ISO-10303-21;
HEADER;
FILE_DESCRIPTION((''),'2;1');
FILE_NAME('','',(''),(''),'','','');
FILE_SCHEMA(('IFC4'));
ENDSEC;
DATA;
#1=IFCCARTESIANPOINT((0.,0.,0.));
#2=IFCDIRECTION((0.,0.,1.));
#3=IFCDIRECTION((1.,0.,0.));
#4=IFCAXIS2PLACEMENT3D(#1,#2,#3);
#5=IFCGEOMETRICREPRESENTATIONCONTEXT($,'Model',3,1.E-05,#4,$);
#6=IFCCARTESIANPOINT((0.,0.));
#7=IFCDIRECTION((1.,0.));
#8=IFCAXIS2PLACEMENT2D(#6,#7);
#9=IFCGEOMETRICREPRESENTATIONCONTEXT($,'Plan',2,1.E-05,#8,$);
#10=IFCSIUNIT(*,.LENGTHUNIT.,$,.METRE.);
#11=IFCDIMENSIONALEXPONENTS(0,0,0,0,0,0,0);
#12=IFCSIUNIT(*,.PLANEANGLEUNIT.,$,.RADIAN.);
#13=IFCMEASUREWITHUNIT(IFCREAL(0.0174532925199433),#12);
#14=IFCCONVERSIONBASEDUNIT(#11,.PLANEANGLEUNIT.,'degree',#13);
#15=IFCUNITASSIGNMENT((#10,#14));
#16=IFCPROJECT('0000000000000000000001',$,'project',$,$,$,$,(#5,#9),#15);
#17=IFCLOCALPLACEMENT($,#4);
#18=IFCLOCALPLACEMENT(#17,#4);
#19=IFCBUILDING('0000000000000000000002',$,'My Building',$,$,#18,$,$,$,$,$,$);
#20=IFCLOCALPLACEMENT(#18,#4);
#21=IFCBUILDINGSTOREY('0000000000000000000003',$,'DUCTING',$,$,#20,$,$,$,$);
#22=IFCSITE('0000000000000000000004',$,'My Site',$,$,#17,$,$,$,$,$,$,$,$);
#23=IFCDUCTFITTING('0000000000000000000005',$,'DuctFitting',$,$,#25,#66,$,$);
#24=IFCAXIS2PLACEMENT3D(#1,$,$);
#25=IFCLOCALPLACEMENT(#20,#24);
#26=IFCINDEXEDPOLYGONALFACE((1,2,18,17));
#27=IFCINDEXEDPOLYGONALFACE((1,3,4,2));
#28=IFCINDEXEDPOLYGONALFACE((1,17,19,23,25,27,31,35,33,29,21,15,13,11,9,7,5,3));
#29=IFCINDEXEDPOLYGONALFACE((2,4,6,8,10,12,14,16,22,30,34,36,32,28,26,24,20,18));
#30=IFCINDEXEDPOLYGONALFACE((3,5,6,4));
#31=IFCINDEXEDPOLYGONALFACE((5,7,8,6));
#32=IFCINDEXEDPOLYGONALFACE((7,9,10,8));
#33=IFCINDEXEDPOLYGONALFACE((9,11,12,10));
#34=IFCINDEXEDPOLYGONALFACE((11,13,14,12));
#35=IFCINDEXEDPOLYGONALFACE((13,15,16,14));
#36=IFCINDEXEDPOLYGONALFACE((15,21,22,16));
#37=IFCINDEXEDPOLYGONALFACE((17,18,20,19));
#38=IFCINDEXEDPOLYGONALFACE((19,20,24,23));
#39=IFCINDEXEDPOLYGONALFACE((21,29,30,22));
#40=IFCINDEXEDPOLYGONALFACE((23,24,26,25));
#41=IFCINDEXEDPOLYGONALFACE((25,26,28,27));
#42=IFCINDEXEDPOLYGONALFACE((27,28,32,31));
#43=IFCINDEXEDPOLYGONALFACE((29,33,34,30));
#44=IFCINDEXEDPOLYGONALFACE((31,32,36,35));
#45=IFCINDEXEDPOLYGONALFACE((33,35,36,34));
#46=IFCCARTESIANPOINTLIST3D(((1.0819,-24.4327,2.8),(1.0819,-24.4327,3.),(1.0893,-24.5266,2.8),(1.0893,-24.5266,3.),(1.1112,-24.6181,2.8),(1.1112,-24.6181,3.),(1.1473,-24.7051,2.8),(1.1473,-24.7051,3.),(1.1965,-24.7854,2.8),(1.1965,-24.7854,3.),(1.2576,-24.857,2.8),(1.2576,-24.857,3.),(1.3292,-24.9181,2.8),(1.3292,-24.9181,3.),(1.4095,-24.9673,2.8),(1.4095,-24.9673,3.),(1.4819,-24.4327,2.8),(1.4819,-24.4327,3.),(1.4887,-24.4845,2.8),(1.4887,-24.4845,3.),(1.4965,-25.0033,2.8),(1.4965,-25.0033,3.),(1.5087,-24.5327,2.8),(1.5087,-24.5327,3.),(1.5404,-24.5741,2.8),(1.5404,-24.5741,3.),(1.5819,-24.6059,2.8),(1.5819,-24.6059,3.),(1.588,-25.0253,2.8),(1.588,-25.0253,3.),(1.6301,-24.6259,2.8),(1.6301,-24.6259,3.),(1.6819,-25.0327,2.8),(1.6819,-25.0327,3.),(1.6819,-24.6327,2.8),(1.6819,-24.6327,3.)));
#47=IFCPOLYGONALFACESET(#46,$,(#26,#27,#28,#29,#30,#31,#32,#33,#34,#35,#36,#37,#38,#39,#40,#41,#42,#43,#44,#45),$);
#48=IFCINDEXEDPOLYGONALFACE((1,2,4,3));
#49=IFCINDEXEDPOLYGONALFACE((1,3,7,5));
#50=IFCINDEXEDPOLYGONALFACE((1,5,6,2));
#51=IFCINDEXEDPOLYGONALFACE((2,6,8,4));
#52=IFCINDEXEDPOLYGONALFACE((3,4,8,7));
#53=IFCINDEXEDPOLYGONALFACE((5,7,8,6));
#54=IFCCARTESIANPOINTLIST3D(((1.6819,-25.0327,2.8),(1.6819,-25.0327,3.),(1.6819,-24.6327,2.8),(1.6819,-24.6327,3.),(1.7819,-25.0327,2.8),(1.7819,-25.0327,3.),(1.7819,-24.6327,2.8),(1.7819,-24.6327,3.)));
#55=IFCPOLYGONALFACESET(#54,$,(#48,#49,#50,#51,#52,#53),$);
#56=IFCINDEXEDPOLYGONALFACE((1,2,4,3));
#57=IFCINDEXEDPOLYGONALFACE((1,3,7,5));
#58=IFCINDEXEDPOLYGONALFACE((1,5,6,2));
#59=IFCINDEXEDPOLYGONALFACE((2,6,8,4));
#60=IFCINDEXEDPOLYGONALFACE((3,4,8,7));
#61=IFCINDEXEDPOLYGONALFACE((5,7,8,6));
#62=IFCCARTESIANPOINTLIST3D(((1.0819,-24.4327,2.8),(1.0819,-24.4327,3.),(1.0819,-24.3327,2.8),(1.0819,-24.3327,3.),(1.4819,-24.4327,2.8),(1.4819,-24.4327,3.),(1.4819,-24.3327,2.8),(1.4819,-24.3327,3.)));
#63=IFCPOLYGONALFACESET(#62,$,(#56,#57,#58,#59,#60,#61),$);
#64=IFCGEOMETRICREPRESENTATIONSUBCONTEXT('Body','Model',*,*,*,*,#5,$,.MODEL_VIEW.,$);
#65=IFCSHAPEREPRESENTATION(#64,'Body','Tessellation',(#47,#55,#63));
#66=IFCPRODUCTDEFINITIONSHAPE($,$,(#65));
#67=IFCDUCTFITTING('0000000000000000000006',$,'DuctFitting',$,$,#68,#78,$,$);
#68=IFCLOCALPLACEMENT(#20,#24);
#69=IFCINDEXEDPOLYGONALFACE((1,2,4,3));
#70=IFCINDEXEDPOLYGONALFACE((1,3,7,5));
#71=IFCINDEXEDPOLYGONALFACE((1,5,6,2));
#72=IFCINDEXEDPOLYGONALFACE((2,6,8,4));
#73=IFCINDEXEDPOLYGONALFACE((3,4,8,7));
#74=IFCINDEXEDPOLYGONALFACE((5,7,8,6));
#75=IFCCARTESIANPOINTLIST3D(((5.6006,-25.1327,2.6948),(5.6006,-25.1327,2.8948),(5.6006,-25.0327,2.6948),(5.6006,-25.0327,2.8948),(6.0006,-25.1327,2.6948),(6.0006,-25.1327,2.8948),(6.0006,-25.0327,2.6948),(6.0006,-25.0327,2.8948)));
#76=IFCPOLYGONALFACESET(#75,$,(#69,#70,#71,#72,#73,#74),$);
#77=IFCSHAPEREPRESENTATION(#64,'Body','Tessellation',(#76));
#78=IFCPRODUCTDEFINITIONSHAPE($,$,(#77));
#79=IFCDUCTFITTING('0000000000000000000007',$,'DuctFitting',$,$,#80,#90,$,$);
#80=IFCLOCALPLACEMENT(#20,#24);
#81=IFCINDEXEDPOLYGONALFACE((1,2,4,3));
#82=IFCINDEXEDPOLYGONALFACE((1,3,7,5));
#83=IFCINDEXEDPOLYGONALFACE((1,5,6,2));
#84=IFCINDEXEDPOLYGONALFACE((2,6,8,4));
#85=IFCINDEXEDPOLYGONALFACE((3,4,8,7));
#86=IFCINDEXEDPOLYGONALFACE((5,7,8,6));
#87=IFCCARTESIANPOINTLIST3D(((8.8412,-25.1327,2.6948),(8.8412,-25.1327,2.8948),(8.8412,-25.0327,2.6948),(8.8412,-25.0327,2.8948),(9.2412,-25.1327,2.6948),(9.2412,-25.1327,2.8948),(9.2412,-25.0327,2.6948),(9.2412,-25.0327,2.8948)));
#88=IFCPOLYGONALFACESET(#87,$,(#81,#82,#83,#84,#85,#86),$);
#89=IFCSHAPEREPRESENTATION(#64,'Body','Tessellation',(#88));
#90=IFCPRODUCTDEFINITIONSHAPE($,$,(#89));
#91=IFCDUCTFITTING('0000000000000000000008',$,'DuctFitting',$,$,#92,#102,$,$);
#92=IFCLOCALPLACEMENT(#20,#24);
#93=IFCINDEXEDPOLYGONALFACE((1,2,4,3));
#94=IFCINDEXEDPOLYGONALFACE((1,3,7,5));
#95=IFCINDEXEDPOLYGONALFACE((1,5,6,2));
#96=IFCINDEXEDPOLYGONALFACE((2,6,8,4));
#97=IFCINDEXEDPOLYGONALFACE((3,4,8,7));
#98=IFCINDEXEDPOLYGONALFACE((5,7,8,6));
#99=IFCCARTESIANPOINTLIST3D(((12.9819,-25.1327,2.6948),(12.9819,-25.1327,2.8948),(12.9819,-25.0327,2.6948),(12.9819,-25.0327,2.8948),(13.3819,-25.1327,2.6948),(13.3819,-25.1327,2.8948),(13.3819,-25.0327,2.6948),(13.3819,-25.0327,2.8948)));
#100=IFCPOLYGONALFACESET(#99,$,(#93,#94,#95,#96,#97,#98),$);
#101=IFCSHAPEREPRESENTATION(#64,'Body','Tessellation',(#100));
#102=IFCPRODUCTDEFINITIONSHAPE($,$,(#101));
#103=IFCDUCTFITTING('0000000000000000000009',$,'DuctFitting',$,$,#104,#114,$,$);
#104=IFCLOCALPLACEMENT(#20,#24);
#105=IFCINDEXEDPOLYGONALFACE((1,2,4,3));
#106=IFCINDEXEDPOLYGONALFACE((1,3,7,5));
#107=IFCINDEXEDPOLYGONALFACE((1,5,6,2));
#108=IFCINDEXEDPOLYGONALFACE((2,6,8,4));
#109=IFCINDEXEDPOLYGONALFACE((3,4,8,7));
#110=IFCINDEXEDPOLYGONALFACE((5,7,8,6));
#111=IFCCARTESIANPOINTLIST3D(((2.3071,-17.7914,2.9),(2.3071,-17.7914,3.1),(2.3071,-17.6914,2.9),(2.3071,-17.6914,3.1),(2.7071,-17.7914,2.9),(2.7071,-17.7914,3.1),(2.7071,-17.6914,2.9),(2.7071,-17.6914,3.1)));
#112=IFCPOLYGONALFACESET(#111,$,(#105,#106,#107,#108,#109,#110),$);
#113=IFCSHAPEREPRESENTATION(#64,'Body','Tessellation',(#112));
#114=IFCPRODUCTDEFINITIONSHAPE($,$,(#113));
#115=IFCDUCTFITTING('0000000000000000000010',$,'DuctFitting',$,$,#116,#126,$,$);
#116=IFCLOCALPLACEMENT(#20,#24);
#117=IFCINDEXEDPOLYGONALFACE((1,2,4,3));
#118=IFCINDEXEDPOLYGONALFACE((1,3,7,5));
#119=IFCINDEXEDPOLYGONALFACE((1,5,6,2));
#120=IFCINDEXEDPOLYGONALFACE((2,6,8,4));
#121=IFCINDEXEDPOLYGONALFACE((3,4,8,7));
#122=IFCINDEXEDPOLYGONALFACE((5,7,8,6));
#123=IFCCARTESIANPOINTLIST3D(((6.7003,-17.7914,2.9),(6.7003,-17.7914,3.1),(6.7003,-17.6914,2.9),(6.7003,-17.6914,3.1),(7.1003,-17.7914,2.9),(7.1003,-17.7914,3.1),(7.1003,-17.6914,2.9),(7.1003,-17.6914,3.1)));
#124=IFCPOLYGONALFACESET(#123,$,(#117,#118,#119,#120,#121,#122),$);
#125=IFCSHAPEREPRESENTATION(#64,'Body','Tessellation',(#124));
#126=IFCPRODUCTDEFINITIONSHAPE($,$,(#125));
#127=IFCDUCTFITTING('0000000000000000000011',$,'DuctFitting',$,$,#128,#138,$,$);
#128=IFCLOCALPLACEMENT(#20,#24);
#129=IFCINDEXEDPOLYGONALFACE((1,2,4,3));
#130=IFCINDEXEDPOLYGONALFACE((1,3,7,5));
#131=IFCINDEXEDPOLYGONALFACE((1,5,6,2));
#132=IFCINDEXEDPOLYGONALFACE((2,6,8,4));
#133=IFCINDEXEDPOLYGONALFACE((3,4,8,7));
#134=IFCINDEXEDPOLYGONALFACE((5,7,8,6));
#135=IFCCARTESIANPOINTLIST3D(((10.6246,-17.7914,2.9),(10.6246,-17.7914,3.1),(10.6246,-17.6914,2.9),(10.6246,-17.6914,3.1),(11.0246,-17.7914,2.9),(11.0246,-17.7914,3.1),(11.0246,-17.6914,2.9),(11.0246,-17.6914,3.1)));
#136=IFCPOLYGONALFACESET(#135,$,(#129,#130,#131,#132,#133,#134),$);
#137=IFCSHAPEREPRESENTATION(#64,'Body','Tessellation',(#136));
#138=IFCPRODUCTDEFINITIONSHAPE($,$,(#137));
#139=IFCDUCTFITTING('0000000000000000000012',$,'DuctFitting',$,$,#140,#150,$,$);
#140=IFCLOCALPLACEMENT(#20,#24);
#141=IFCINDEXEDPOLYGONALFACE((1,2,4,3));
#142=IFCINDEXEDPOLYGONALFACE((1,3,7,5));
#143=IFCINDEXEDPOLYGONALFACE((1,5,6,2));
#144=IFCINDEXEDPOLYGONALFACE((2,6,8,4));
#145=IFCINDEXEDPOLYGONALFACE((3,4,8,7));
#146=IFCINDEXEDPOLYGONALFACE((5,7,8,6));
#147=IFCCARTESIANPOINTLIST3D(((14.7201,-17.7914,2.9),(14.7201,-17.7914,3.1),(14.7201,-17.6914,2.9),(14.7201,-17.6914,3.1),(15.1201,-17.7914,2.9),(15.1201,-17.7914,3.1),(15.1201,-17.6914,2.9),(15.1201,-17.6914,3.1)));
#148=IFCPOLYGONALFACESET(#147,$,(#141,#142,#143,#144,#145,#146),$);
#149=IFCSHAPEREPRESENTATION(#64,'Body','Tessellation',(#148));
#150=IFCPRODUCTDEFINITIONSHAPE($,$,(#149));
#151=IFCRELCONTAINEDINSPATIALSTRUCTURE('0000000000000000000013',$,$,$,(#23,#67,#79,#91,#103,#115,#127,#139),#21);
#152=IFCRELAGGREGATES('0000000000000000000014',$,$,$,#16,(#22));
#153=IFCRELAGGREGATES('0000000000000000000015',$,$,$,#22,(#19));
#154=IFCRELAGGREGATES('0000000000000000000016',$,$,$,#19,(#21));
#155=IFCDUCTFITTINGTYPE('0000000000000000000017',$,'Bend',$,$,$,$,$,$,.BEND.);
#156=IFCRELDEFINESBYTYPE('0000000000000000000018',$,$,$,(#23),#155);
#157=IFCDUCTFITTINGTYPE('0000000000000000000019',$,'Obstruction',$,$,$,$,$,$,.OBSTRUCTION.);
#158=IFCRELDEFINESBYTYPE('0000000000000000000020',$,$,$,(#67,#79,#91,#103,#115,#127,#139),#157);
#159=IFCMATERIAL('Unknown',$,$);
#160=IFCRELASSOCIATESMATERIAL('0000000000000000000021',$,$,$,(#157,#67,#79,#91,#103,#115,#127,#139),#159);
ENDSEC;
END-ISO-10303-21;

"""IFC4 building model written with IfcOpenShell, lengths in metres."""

from ifc_helpers import new_model, entity, si_unit, converted_unit, frame, origin_with_axes, origin_2d_with_axis, place, context, subcontext, project, spatial, line, arc, indexed_curve, rectangle, outline, extrude, source, transform, mapped, material, material_profile, profile_set, profile_usage, type_object, type_shapes, element, save


model = new_model("IFC4")

# Units and contexts
model_context = context("Model", 3, precision=1e-05, world=origin_with_axes())
plan_context = context("Plan", 2, precision=1e-05, world=origin_2d_with_axis())
body_context = subcontext(model_context, "Body", "Model", "MODEL_VIEW")
ifc_project = project(units=[si_unit("LENGTHUNIT", "METRE"), converted_unit("PLANEANGLEUNIT", "degree", entity("IfcReal", 0.0174532925199433), si_unit("PLANEANGLEUNIT", "RADIAN"), dimensions=[0, 0, 0, 0, 0, 0, 0])], contexts=[model_context, plan_context])

# Site, building, storey
site_placement = place(None, origin_with_axes())
site = spatial("IfcSite", under=ifc_project, at=site_placement, Name="My Site")
building_placement = place(site_placement, origin_with_axes())
building = spatial("IfcBuilding", under=site, at=building_placement, Name="My Building")
storey_placement = place(building_placement, origin_with_axes())
storey = spatial("IfcBuildingStorey", under=building, at=storey_placement, Name="DUCTING")

# Shared definitions
ifc_material = material(Name="Unknown")

# Duct fittings
duct_fitting_type_1 = type_object("IfcDuctFittingType", Name="Bend", PredefinedType="BEND")
shared_shape = source(origin_with_axes(), body_context, "Body", "SweptSolid", [
    extrude(outline(indexed_curve([(-0.2, 0.0), (-0.2586, -0.1414), (-0.4, -0.2), (-0.4, -0.6), (0.0243, -0.4243), (0.2, 0.0)], segments=[arc(1, 2, 3), line(3, 4), arc(4, 5, 6), line(6, 1)])), frame((0.0, -0.1, -0.1), z_axis=(0.0, -1.0, 0.0), x_axis=(1.0, 0.0, 0.0)), (0.0, 0.0, -1.0), 0.2),
    extrude(rectangle(XDim=0.4, YDim=0.2), origin_with_axes(), (0.0, 0.0, -1.0), 0.1),
    extrude(rectangle(XDim=0.4, YDim=0.2), frame((-0.4, 0.0, -0.5), z_axis=(-1.0, 0.0, 0.0), x_axis=(0.0, 0.0, -1.0)), (0.0, 0.0, 1.0), 0.1),
])
type_shapes(duct_fitting_type_1, [shared_shape])
for number, where, z_axis, x_axis, name in (
    (1, (1.7819, -24.8327, 2.9), (1.0, 0.0, 0.0), (0.0, -1.0, 0.0), "DuctFitting"),
):
    element("IfcDuctFitting", number, at=place(storey_placement, frame(where, z_axis=z_axis, x_axis=x_axis)), inside=storey, type_object=duct_fitting_type_1, Name=name, context=body_context, shape_type="MappedRepresentation", body=[
        mapped(shared_shape, transform((0.0, 0.0, 0.0), x_axis=(1.0, 0.0, 0.0), y_axis=(0.0, 1.0, 0.0), z_axis=(0.0, 0.0, 1.0), scale=1.0)),
    ])
ifc_material_profile_1 = material_profile(ifc_material, rectangle(XDim=0.4, YDim=0.2))
ifc_profile_set_1 = profile_set([ifc_material_profile_1])
ifc_profile_usage_1 = profile_usage(ifc_profile_set_1, cardinal=5)
duct_fitting_type_2 = type_object("IfcDuctFittingType", Name="Obstruction", PredefinedType="OBSTRUCTION", material=ifc_profile_set_1)
duct_fitting_1_placement = place(storey_placement, frame((5.8006, -25.0327, 2.7948), z_axis=(0.0, -1.0, 0.0), x_axis=(1.0, 0.0, 0.0)))
element("IfcDuctFitting", 2, at=duct_fitting_1_placement, inside=storey, type_object=duct_fitting_type_2, material=ifc_profile_usage_1, Name="DuctFitting", context=body_context, shape_type="SweptSolid", body=[
    extrude(rectangle(XDim=0.4, YDim=0.2), origin_with_axes(), (0.0, 0.0, 1.0), 0.1),
])
ifc_profile_usage_2 = profile_usage(ifc_profile_set_1, cardinal=5)
duct_fitting_2_placement = place(storey_placement, frame((9.0412, -25.0327, 2.7948), z_axis=(0.0, -1.0, 0.0), x_axis=(1.0, 0.0, 0.0)))
element("IfcDuctFitting", 3, at=duct_fitting_2_placement, inside=storey, type_object=duct_fitting_type_2, material=ifc_profile_usage_2, Name="DuctFitting", context=body_context, shape_type="SweptSolid", body=[
    extrude(rectangle(XDim=0.4, YDim=0.2), origin_with_axes(), (0.0, 0.0, 1.0), 0.1),
])
ifc_profile_usage_3 = profile_usage(ifc_profile_set_1, cardinal=5)
duct_fitting_3_placement = place(storey_placement, frame((13.1819, -25.0327, 2.7948), z_axis=(0.0, -1.0, 0.0), x_axis=(1.0, 0.0, 0.0)))
element("IfcDuctFitting", 4, at=duct_fitting_3_placement, inside=storey, type_object=duct_fitting_type_2, material=ifc_profile_usage_3, Name="DuctFitting", context=body_context, shape_type="SweptSolid", body=[
    extrude(rectangle(XDim=0.4, YDim=0.2), origin_with_axes(), (0.0, 0.0, 1.0), 0.1),
])
ifc_profile_usage_4 = profile_usage(ifc_profile_set_1, cardinal=5)
duct_fitting_4_placement = place(storey_placement, frame((2.5071, -17.7914, 3.0), z_axis=(0.0, 1.0, 0.0), x_axis=(-1.0, 0.0, 0.0)))
element("IfcDuctFitting", 5, at=duct_fitting_4_placement, inside=storey, type_object=duct_fitting_type_2, material=ifc_profile_usage_4, Name="DuctFitting", context=body_context, shape_type="SweptSolid", body=[
    extrude(rectangle(XDim=0.4, YDim=0.2), origin_with_axes(), (0.0, 0.0, 1.0), 0.1),
])
ifc_profile_usage_5 = profile_usage(ifc_profile_set_1, cardinal=5)
duct_fitting_5_placement = place(storey_placement, frame((6.9003, -17.7914, 3.0), z_axis=(0.0, 1.0, 0.0), x_axis=(-1.0, 0.0, 0.0)))
element("IfcDuctFitting", 6, at=duct_fitting_5_placement, inside=storey, type_object=duct_fitting_type_2, material=ifc_profile_usage_5, Name="DuctFitting", context=body_context, shape_type="SweptSolid", body=[
    extrude(rectangle(XDim=0.4, YDim=0.2), origin_with_axes(), (0.0, 0.0, 1.0), 0.1),
])
ifc_profile_usage_6 = profile_usage(ifc_profile_set_1, cardinal=5)
duct_fitting_6_placement = place(storey_placement, frame((10.8246, -17.7914, 3.0), z_axis=(0.0, 1.0, 0.0), x_axis=(-1.0, 0.0, 0.0)))
element("IfcDuctFitting", 7, at=duct_fitting_6_placement, inside=storey, type_object=duct_fitting_type_2, material=ifc_profile_usage_6, Name="DuctFitting", context=body_context, shape_type="SweptSolid", body=[
    extrude(rectangle(XDim=0.4, YDim=0.2), origin_with_axes(), (0.0, 0.0, 1.0), 0.1),
])
ifc_profile_usage_7 = profile_usage(ifc_profile_set_1, cardinal=5)
duct_fitting_7_placement = place(storey_placement, frame((14.9201, -17.7914, 3.0), z_axis=(0.0, 1.0, 0.0), x_axis=(-1.0, 0.0, 0.0)))
element("IfcDuctFitting", 8, at=duct_fitting_7_placement, inside=storey, type_object=duct_fitting_type_2, material=ifc_profile_usage_7, Name="DuctFitting", context=body_context, shape_type="SweptSolid", body=[
    extrude(rectangle(XDim=0.4, YDim=0.2), origin_with_axes(), (0.0, 0.0, 1.0), 0.1),
])

save(model, "model.ifc")
